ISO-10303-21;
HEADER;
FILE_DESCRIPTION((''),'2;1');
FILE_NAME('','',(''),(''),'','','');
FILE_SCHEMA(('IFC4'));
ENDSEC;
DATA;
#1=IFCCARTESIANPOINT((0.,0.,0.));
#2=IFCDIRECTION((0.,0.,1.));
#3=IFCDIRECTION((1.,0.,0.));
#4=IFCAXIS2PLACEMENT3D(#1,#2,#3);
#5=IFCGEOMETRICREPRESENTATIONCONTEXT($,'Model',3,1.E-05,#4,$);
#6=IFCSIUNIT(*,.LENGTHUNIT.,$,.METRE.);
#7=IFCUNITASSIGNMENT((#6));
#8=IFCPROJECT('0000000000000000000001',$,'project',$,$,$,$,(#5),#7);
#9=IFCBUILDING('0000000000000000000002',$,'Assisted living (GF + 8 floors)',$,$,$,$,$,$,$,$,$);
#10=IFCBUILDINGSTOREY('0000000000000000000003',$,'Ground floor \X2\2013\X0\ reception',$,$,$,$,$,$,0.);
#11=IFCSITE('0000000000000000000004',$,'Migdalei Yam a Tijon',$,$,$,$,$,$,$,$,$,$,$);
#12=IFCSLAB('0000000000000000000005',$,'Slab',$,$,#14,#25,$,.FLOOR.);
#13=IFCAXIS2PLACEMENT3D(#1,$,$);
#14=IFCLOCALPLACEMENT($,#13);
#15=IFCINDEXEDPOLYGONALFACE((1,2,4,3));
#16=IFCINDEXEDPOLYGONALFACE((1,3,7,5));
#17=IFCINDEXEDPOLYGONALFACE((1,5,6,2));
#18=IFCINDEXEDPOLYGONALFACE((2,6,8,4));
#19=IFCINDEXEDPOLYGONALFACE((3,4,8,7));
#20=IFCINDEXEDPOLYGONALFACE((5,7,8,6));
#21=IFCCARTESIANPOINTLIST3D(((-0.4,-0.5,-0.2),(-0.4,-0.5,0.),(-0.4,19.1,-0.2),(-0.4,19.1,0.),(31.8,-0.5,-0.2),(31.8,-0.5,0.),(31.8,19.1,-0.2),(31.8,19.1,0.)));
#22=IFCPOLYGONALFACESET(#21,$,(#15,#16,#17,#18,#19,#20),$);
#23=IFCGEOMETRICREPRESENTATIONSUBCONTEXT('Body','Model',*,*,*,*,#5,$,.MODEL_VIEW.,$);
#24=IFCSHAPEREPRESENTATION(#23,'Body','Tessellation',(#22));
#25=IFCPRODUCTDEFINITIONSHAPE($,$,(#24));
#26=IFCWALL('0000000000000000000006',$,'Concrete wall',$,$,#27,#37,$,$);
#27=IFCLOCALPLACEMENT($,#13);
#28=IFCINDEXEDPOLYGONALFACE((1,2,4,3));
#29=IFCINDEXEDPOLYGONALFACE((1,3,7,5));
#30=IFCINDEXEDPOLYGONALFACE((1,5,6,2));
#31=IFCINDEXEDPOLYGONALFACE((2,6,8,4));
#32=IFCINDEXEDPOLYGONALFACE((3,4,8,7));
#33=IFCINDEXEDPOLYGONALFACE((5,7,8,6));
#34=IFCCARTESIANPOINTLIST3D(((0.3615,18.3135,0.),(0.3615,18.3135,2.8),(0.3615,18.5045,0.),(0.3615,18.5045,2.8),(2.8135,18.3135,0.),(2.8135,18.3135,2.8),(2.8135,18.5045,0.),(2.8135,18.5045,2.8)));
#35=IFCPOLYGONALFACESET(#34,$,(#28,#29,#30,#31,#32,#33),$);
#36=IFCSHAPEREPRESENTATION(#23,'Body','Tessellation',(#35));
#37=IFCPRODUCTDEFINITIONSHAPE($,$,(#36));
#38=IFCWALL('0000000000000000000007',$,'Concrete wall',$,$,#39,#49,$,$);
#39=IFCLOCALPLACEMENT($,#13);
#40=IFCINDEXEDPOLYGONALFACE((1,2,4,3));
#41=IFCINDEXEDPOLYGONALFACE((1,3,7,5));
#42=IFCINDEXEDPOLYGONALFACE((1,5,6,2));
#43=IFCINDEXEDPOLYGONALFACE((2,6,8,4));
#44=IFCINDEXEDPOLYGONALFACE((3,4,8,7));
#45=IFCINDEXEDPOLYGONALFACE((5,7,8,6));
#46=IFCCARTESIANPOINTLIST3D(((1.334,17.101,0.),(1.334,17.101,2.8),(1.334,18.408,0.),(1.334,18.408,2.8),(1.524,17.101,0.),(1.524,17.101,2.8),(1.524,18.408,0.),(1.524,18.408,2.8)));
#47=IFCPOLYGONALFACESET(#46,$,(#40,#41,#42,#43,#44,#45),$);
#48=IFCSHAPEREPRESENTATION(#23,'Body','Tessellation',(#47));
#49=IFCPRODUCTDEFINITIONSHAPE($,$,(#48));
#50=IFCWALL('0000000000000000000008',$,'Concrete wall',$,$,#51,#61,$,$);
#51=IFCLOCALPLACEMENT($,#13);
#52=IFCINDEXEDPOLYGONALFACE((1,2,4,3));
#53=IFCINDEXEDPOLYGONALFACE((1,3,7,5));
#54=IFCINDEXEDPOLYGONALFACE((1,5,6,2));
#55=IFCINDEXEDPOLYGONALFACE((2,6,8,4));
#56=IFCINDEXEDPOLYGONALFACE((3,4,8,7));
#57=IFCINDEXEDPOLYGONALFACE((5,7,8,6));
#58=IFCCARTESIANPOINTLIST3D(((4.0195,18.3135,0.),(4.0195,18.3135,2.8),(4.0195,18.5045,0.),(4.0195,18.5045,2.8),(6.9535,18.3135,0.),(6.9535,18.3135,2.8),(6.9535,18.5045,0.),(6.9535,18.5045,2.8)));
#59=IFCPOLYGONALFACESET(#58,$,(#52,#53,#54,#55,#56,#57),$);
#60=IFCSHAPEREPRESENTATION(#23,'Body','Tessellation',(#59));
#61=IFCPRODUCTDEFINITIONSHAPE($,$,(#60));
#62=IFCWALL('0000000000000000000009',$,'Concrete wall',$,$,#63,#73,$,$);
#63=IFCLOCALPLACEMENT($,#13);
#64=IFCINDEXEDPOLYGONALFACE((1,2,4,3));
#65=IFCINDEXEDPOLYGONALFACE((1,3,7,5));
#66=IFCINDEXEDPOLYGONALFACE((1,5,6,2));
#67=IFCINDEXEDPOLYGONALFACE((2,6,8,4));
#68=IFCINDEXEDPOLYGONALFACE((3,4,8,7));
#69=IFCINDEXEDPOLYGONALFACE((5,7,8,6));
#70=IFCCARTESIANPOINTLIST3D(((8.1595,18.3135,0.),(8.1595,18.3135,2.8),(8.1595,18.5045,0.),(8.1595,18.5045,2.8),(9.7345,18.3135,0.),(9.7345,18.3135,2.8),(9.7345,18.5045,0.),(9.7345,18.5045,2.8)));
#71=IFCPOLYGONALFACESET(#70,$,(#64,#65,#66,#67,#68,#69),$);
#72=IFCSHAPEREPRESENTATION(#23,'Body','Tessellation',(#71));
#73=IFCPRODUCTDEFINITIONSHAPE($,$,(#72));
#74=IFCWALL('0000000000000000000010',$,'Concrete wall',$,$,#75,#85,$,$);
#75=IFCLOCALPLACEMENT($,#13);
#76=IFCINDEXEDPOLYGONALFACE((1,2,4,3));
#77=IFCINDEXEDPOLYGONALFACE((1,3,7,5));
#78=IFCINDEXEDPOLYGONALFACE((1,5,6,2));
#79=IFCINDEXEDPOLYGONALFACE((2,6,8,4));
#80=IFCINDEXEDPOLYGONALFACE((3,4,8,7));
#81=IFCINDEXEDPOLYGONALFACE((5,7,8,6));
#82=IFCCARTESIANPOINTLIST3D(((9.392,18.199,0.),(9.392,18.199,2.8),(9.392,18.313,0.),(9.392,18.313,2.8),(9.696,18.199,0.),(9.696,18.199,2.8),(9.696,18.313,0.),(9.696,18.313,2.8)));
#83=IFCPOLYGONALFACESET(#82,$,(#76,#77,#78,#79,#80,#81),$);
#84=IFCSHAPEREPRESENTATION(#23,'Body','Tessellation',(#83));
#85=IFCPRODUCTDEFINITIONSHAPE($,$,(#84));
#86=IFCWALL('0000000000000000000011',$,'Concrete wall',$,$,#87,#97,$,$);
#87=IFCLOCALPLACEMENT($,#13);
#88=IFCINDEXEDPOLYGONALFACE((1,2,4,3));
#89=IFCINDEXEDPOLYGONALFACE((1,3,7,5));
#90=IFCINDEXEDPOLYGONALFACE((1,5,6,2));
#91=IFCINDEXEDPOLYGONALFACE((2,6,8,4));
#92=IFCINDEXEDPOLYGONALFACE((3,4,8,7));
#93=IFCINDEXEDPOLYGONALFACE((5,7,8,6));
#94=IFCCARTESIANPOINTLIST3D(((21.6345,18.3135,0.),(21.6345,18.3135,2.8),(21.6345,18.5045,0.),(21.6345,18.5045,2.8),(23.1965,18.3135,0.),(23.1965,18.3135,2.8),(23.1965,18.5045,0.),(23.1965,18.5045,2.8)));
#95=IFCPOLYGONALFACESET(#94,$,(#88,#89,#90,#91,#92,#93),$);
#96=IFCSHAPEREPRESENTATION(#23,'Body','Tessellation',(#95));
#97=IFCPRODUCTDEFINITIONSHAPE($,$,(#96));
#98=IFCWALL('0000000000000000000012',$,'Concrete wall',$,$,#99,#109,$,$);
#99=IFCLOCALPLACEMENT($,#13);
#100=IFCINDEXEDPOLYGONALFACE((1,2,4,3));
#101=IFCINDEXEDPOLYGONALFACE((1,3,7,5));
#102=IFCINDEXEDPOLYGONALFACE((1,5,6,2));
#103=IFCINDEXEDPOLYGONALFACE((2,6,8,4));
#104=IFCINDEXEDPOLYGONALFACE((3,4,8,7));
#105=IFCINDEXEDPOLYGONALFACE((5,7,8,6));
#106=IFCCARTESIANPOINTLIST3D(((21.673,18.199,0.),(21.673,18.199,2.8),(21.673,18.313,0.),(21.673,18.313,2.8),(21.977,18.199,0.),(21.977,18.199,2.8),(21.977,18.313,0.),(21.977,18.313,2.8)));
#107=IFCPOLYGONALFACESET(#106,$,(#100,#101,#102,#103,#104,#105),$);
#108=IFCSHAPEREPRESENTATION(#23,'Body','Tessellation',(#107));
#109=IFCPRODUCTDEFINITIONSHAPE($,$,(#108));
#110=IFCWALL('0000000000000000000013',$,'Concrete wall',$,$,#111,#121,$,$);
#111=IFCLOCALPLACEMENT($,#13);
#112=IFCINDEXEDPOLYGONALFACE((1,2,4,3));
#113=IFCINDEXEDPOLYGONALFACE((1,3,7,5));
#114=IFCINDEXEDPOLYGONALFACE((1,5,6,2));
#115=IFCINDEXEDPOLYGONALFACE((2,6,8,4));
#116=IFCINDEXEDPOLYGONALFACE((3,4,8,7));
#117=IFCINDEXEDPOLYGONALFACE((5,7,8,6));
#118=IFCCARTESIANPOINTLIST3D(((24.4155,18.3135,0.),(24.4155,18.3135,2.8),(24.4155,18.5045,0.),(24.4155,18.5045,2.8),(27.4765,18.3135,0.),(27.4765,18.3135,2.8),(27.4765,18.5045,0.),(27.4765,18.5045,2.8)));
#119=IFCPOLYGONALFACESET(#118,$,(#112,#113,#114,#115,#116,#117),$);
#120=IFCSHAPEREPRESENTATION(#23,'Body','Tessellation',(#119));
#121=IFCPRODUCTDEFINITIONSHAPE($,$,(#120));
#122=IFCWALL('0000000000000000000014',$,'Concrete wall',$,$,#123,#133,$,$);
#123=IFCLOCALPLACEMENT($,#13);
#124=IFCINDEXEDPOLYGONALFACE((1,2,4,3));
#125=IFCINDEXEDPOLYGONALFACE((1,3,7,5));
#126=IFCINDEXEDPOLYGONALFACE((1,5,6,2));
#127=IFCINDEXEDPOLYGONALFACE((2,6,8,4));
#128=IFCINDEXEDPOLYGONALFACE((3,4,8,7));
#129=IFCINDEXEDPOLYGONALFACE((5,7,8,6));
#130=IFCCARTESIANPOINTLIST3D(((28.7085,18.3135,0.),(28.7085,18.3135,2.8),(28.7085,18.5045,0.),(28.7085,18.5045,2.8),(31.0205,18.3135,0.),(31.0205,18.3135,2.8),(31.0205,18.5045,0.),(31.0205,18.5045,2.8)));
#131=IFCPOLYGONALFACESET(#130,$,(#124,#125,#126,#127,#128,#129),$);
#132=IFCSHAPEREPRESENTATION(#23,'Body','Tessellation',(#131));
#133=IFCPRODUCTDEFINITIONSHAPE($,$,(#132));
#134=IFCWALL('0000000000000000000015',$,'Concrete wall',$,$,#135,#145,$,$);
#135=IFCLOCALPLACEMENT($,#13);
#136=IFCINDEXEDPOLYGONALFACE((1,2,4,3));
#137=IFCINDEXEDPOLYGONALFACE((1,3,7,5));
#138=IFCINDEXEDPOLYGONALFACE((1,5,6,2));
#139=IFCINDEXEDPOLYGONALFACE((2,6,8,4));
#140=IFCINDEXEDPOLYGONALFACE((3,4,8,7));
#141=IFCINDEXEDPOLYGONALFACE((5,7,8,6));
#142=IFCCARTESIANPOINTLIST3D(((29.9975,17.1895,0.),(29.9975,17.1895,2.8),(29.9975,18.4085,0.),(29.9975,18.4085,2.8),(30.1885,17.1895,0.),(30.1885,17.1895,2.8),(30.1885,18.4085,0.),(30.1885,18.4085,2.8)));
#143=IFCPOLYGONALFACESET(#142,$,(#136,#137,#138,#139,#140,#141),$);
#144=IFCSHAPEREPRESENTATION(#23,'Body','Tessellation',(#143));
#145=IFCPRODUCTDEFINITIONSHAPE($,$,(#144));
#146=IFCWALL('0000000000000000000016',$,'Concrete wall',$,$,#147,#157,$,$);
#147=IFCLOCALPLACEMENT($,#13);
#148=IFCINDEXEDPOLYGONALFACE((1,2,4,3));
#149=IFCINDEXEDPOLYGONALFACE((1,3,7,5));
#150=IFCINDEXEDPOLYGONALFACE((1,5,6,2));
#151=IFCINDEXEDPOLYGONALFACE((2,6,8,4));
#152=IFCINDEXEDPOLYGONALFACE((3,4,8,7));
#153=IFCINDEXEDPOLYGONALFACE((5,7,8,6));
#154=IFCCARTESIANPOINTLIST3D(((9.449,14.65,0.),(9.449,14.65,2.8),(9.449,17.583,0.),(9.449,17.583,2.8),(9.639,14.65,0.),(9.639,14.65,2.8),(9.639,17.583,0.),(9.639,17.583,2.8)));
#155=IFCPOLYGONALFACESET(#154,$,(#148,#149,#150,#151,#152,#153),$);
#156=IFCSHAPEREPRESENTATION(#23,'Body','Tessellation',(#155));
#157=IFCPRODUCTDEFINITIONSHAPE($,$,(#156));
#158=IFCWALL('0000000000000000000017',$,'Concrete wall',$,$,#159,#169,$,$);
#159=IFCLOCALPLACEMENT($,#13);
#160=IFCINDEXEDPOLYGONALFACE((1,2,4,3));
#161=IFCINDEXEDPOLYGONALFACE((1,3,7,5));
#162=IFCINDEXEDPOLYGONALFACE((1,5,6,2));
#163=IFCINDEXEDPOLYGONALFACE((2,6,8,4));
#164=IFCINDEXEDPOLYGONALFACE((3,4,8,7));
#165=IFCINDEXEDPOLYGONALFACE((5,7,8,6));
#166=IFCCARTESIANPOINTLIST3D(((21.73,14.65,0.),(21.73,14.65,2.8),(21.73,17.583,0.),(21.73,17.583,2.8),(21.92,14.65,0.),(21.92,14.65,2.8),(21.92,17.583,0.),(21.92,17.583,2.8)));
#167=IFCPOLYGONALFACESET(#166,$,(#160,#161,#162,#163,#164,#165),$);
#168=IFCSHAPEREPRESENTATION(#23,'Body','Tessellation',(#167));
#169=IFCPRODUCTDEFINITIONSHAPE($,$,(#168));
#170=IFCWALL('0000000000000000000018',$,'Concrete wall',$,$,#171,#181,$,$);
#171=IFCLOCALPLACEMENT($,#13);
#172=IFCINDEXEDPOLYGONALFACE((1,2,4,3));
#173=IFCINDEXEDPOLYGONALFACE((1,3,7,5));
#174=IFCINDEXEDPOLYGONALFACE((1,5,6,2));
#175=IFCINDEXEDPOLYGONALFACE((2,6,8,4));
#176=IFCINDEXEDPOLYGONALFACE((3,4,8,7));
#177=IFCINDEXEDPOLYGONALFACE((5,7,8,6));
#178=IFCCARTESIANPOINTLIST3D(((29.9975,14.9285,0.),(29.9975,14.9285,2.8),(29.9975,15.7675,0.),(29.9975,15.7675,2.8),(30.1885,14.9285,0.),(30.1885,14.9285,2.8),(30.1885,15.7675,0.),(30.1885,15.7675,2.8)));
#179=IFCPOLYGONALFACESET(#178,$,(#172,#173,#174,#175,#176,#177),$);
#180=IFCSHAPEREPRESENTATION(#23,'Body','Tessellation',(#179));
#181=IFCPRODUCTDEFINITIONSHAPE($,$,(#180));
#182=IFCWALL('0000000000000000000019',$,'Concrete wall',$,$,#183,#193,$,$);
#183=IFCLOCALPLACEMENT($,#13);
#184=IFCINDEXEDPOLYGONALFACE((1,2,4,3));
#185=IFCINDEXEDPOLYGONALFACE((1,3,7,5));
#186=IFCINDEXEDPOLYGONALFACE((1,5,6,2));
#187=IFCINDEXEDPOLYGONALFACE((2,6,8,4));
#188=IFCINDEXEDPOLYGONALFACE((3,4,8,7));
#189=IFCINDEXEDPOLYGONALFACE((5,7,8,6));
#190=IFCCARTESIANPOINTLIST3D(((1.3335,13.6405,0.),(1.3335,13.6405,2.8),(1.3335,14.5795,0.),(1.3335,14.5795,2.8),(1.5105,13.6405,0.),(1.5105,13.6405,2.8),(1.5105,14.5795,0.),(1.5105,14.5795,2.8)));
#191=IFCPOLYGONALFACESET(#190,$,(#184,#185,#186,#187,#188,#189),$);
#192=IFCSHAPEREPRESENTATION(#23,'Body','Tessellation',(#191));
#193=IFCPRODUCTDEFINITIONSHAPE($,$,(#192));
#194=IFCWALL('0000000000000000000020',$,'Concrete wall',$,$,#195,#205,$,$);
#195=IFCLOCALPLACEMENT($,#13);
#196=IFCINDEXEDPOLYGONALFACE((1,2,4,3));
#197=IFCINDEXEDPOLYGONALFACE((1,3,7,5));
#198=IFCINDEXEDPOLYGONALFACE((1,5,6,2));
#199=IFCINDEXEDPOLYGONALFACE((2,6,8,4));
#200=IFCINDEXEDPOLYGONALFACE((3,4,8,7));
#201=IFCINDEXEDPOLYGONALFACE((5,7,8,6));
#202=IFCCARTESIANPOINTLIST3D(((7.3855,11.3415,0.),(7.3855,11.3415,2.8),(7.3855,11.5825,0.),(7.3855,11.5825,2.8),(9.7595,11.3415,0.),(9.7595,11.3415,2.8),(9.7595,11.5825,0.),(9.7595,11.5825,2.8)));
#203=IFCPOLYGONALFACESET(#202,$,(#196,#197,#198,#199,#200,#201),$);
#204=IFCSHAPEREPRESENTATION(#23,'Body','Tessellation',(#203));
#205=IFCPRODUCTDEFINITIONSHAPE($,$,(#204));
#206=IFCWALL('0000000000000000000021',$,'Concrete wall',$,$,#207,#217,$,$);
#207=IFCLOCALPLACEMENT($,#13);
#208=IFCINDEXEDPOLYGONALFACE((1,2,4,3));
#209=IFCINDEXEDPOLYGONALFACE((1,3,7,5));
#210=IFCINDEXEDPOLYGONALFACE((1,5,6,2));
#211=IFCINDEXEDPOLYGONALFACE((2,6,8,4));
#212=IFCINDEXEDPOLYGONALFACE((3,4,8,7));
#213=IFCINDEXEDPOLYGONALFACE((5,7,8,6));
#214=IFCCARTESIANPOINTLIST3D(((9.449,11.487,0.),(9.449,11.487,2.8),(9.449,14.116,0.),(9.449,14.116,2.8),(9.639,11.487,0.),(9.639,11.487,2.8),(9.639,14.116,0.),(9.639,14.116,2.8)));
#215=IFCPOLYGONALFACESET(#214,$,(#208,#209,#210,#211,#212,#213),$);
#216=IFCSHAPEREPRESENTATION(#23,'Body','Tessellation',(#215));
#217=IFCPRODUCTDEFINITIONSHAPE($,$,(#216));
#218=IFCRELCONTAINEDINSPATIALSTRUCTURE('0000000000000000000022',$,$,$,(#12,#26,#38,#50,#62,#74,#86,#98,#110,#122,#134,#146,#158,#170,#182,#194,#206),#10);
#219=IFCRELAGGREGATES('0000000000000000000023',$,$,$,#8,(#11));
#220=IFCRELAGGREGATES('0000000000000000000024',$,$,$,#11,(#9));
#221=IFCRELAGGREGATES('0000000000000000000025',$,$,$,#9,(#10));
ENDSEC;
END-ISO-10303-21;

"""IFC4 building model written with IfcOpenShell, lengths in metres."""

from ifc_helpers import new_model, si_unit, frame, origin_with_axes, context, subcontext, project, spatial, line, indexed_curve, outline, extrude, element, save


model = new_model("IFC4")

# Units and contexts
model_context = context("Model", 3, precision=1e-05, world=origin_with_axes())
body_context = subcontext(model_context, "Body", "Model", "MODEL_VIEW")
ifc_project = project(units=[si_unit("LENGTHUNIT", "METRE")], contexts=[model_context])

# Site, building, storey
site = spatial("IfcSite", under=ifc_project, Name="Migdalei Yam a Tijon")
building = spatial("IfcBuilding", under=site, Name="Assisted living (GF + 8 floors)")
storey = spatial("IfcBuildingStorey", under=building, Name="Ground floor – reception", Elevation=0.0)

# Slab
element("IfcSlab", 1, inside=storey, Name="Slab", PredefinedType="FLOOR", context=body_context, shape_type="SweptSolid", body=[
    extrude(outline(indexed_curve([(0.0, 0.0), (32.2, 0.0), (32.2, 19.6), (0.0, 19.6)], segments=[line(1, 2, 3, 4, 1)])), frame((-0.4, -0.5, -0.2), z_axis=(0.0, 0.0, 1.0), x_axis=(1.0, 0.0, 0.0)), (0.0, 0.0, 1.0), 0.2),
])

# Walls
element("IfcWall", 2, inside=storey, Name="Concrete wall", context=body_context, shape_type="SweptSolid", body=[
    extrude(outline(indexed_curve([(0.0, 0.0), (2.452, 0.0), (2.452, 0.191), (0.0, 0.191)], segments=[line(1, 2, 3, 4, 1)])), frame((0.3615, 18.3135, 0.0), z_axis=(0.0, 0.0, 1.0), x_axis=(1.0, 0.0, 0.0)), (0.0, 0.0, 1.0), 2.8),
])
element("IfcWall", 3, inside=storey, Name="Concrete wall", context=body_context, shape_type="SweptSolid", body=[
    extrude(outline(indexed_curve([(0.0, 0.0), (0.19, 0.0), (0.19, 1.307), (0.0, 1.307)], segments=[line(1, 2, 3, 4, 1)])), frame((1.334, 17.101, 0.0), z_axis=(0.0, 0.0, 1.0), x_axis=(1.0, 0.0, 0.0)), (0.0, 0.0, 1.0), 2.8),
])
element("IfcWall", 4, inside=storey, Name="Concrete wall", context=body_context, shape_type="SweptSolid", body=[
    extrude(outline(indexed_curve([(0.0, 0.0), (2.934, 0.0), (2.934, 0.191), (0.0, 0.191)], segments=[line(1, 2, 3, 4, 1)])), frame((4.0195, 18.3135, 0.0), z_axis=(0.0, 0.0, 1.0), x_axis=(1.0, 0.0, 0.0)), (0.0, 0.0, 1.0), 2.8),
])
element("IfcWall", 5, inside=storey, Name="Concrete wall", context=body_context, shape_type="SweptSolid", body=[
    extrude(outline(indexed_curve([(0.0, 0.0), (1.575, 0.0), (1.575, 0.191), (0.0, 0.191)], segments=[line(1, 2, 3, 4, 1)])), frame((8.1595, 18.3135, 0.0), z_axis=(0.0, 0.0, 1.0), x_axis=(1.0, 0.0, 0.0)), (0.0, 0.0, 1.0), 2.8),
])
element("IfcWall", 6, inside=storey, Name="Concrete wall", context=body_context, shape_type="SweptSolid", body=[
    extrude(outline(indexed_curve([(0.0, 0.0), (0.304, 0.0), (0.304, 0.114), (0.0, 0.114)], segments=[line(1, 2, 3, 4, 1)])), frame((9.392, 18.199, 0.0), z_axis=(0.0, 0.0, 1.0), x_axis=(1.0, 0.0, 0.0)), (0.0, 0.0, 1.0), 2.8),
])
element("IfcWall", 7, inside=storey, Name="Concrete wall", context=body_context, shape_type="SweptSolid", body=[
    extrude(outline(indexed_curve([(0.0, 0.0), (1.562, 0.0), (1.562, 0.191), (0.0, 0.191)], segments=[line(1, 2, 3, 4, 1)])), frame((21.6345, 18.3135, 0.0), z_axis=(0.0, 0.0, 1.0), x_axis=(1.0, 0.0, 0.0)), (0.0, 0.0, 1.0), 2.8),
])
element("IfcWall", 8, inside=storey, Name="Concrete wall", context=body_context, shape_type="SweptSolid", body=[
    extrude(outline(indexed_curve([(0.0, 0.0), (0.304, 0.0), (0.304, 0.114), (0.0, 0.114)], segments=[line(1, 2, 3, 4, 1)])), frame((21.673, 18.199, 0.0), z_axis=(0.0, 0.0, 1.0), x_axis=(1.0, 0.0, 0.0)), (0.0, 0.0, 1.0), 2.8),
])
element("IfcWall", 9, inside=storey, Name="Concrete wall", context=body_context, shape_type="SweptSolid", body=[
    extrude(outline(indexed_curve([(0.0, 0.0), (3.061, 0.0), (3.061, 0.191), (0.0, 0.191)], segments=[line(1, 2, 3, 4, 1)])), frame((24.4155, 18.3135, 0.0), z_axis=(0.0, 0.0, 1.0), x_axis=(1.0, 0.0, 0.0)), (0.0, 0.0, 1.0), 2.8),
])
element("IfcWall", 10, inside=storey, Name="Concrete wall", context=body_context, shape_type="SweptSolid", body=[
    extrude(outline(indexed_curve([(0.0, 0.0), (2.312, 0.0), (2.312, 0.191), (0.0, 0.191)], segments=[line(1, 2, 3, 4, 1)])), frame((28.7085, 18.3135, 0.0), z_axis=(0.0, 0.0, 1.0), x_axis=(1.0, 0.0, 0.0)), (0.0, 0.0, 1.0), 2.8),
])
element("IfcWall", 11, inside=storey, Name="Concrete wall", context=body_context, shape_type="SweptSolid", body=[
    extrude(outline(indexed_curve([(0.0, 0.0), (0.191, 0.0), (0.191, 1.219), (0.0, 1.219)], segments=[line(1, 2, 3, 4, 1)])), frame((29.9975, 17.1895, 0.0), z_axis=(0.0, 0.0, 1.0), x_axis=(1.0, 0.0, 0.0)), (0.0, 0.0, 1.0), 2.8),
])
element("IfcWall", 12, inside=storey, Name="Concrete wall", context=body_context, shape_type="SweptSolid", body=[
    extrude(outline(indexed_curve([(0.0, 0.0), (0.19, 0.0), (0.19, 2.933), (0.0, 2.933)], segments=[line(1, 2, 3, 4, 1)])), frame((9.449, 14.65, 0.0), z_axis=(0.0, 0.0, 1.0), x_axis=(1.0, 0.0, 0.0)), (0.0, 0.0, 1.0), 2.8),
])
element("IfcWall", 13, inside=storey, Name="Concrete wall", context=body_context, shape_type="SweptSolid", body=[
    extrude(outline(indexed_curve([(0.0, 0.0), (0.19, 0.0), (0.19, 2.933), (0.0, 2.933)], segments=[line(1, 2, 3, 4, 1)])), frame((21.73, 14.65, 0.0), z_axis=(0.0, 0.0, 1.0), x_axis=(1.0, 0.0, 0.0)), (0.0, 0.0, 1.0), 2.8),
])
element("IfcWall", 14, inside=storey, Name="Concrete wall", context=body_context, shape_type="SweptSolid", body=[
    extrude(outline(indexed_curve([(0.0, 0.0), (0.191, 0.0), (0.191, 0.839), (0.0, 0.839)], segments=[line(1, 2, 3, 4, 1)])), frame((29.9975, 14.9285, 0.0), z_axis=(0.0, 0.0, 1.0), x_axis=(1.0, 0.0, 0.0)), (0.0, 0.0, 1.0), 2.8),
])
element("IfcWall", 15, inside=storey, Name="Concrete wall", context=body_context, shape_type="SweptSolid", body=[
    extrude(outline(indexed_curve([(0.0, 0.0), (0.177, 0.0), (0.177, 0.939), (0.0, 0.939)], segments=[line(1, 2, 3, 4, 1)])), frame((1.3335, 13.6405, 0.0), z_axis=(0.0, 0.0, 1.0), x_axis=(1.0, 0.0, 0.0)), (0.0, 0.0, 1.0), 2.8),
])
element("IfcWall", 16, inside=storey, Name="Concrete wall", context=body_context, shape_type="SweptSolid", body=[
    extrude(outline(indexed_curve([(0.0, 0.0), (2.374, 0.0), (2.374, 0.241), (0.0, 0.241)], segments=[line(1, 2, 3, 4, 1)])), frame((7.3855, 11.3415, 0.0), z_axis=(0.0, 0.0, 1.0), x_axis=(1.0, 0.0, 0.0)), (0.0, 0.0, 1.0), 2.8),
])
element("IfcWall", 17, inside=storey, Name="Concrete wall", context=body_context, shape_type="SweptSolid", body=[
    extrude(outline(indexed_curve([(0.0, 0.0), (0.19, 0.0), (0.19, 2.629), (0.0, 2.629)], segments=[line(1, 2, 3, 4, 1)])), frame((9.449, 11.487, 0.0), z_axis=(0.0, 0.0, 1.0), x_axis=(1.0, 0.0, 0.0)), (0.0, 0.0, 1.0), 2.8),
])

save(model, "model.ifc")
